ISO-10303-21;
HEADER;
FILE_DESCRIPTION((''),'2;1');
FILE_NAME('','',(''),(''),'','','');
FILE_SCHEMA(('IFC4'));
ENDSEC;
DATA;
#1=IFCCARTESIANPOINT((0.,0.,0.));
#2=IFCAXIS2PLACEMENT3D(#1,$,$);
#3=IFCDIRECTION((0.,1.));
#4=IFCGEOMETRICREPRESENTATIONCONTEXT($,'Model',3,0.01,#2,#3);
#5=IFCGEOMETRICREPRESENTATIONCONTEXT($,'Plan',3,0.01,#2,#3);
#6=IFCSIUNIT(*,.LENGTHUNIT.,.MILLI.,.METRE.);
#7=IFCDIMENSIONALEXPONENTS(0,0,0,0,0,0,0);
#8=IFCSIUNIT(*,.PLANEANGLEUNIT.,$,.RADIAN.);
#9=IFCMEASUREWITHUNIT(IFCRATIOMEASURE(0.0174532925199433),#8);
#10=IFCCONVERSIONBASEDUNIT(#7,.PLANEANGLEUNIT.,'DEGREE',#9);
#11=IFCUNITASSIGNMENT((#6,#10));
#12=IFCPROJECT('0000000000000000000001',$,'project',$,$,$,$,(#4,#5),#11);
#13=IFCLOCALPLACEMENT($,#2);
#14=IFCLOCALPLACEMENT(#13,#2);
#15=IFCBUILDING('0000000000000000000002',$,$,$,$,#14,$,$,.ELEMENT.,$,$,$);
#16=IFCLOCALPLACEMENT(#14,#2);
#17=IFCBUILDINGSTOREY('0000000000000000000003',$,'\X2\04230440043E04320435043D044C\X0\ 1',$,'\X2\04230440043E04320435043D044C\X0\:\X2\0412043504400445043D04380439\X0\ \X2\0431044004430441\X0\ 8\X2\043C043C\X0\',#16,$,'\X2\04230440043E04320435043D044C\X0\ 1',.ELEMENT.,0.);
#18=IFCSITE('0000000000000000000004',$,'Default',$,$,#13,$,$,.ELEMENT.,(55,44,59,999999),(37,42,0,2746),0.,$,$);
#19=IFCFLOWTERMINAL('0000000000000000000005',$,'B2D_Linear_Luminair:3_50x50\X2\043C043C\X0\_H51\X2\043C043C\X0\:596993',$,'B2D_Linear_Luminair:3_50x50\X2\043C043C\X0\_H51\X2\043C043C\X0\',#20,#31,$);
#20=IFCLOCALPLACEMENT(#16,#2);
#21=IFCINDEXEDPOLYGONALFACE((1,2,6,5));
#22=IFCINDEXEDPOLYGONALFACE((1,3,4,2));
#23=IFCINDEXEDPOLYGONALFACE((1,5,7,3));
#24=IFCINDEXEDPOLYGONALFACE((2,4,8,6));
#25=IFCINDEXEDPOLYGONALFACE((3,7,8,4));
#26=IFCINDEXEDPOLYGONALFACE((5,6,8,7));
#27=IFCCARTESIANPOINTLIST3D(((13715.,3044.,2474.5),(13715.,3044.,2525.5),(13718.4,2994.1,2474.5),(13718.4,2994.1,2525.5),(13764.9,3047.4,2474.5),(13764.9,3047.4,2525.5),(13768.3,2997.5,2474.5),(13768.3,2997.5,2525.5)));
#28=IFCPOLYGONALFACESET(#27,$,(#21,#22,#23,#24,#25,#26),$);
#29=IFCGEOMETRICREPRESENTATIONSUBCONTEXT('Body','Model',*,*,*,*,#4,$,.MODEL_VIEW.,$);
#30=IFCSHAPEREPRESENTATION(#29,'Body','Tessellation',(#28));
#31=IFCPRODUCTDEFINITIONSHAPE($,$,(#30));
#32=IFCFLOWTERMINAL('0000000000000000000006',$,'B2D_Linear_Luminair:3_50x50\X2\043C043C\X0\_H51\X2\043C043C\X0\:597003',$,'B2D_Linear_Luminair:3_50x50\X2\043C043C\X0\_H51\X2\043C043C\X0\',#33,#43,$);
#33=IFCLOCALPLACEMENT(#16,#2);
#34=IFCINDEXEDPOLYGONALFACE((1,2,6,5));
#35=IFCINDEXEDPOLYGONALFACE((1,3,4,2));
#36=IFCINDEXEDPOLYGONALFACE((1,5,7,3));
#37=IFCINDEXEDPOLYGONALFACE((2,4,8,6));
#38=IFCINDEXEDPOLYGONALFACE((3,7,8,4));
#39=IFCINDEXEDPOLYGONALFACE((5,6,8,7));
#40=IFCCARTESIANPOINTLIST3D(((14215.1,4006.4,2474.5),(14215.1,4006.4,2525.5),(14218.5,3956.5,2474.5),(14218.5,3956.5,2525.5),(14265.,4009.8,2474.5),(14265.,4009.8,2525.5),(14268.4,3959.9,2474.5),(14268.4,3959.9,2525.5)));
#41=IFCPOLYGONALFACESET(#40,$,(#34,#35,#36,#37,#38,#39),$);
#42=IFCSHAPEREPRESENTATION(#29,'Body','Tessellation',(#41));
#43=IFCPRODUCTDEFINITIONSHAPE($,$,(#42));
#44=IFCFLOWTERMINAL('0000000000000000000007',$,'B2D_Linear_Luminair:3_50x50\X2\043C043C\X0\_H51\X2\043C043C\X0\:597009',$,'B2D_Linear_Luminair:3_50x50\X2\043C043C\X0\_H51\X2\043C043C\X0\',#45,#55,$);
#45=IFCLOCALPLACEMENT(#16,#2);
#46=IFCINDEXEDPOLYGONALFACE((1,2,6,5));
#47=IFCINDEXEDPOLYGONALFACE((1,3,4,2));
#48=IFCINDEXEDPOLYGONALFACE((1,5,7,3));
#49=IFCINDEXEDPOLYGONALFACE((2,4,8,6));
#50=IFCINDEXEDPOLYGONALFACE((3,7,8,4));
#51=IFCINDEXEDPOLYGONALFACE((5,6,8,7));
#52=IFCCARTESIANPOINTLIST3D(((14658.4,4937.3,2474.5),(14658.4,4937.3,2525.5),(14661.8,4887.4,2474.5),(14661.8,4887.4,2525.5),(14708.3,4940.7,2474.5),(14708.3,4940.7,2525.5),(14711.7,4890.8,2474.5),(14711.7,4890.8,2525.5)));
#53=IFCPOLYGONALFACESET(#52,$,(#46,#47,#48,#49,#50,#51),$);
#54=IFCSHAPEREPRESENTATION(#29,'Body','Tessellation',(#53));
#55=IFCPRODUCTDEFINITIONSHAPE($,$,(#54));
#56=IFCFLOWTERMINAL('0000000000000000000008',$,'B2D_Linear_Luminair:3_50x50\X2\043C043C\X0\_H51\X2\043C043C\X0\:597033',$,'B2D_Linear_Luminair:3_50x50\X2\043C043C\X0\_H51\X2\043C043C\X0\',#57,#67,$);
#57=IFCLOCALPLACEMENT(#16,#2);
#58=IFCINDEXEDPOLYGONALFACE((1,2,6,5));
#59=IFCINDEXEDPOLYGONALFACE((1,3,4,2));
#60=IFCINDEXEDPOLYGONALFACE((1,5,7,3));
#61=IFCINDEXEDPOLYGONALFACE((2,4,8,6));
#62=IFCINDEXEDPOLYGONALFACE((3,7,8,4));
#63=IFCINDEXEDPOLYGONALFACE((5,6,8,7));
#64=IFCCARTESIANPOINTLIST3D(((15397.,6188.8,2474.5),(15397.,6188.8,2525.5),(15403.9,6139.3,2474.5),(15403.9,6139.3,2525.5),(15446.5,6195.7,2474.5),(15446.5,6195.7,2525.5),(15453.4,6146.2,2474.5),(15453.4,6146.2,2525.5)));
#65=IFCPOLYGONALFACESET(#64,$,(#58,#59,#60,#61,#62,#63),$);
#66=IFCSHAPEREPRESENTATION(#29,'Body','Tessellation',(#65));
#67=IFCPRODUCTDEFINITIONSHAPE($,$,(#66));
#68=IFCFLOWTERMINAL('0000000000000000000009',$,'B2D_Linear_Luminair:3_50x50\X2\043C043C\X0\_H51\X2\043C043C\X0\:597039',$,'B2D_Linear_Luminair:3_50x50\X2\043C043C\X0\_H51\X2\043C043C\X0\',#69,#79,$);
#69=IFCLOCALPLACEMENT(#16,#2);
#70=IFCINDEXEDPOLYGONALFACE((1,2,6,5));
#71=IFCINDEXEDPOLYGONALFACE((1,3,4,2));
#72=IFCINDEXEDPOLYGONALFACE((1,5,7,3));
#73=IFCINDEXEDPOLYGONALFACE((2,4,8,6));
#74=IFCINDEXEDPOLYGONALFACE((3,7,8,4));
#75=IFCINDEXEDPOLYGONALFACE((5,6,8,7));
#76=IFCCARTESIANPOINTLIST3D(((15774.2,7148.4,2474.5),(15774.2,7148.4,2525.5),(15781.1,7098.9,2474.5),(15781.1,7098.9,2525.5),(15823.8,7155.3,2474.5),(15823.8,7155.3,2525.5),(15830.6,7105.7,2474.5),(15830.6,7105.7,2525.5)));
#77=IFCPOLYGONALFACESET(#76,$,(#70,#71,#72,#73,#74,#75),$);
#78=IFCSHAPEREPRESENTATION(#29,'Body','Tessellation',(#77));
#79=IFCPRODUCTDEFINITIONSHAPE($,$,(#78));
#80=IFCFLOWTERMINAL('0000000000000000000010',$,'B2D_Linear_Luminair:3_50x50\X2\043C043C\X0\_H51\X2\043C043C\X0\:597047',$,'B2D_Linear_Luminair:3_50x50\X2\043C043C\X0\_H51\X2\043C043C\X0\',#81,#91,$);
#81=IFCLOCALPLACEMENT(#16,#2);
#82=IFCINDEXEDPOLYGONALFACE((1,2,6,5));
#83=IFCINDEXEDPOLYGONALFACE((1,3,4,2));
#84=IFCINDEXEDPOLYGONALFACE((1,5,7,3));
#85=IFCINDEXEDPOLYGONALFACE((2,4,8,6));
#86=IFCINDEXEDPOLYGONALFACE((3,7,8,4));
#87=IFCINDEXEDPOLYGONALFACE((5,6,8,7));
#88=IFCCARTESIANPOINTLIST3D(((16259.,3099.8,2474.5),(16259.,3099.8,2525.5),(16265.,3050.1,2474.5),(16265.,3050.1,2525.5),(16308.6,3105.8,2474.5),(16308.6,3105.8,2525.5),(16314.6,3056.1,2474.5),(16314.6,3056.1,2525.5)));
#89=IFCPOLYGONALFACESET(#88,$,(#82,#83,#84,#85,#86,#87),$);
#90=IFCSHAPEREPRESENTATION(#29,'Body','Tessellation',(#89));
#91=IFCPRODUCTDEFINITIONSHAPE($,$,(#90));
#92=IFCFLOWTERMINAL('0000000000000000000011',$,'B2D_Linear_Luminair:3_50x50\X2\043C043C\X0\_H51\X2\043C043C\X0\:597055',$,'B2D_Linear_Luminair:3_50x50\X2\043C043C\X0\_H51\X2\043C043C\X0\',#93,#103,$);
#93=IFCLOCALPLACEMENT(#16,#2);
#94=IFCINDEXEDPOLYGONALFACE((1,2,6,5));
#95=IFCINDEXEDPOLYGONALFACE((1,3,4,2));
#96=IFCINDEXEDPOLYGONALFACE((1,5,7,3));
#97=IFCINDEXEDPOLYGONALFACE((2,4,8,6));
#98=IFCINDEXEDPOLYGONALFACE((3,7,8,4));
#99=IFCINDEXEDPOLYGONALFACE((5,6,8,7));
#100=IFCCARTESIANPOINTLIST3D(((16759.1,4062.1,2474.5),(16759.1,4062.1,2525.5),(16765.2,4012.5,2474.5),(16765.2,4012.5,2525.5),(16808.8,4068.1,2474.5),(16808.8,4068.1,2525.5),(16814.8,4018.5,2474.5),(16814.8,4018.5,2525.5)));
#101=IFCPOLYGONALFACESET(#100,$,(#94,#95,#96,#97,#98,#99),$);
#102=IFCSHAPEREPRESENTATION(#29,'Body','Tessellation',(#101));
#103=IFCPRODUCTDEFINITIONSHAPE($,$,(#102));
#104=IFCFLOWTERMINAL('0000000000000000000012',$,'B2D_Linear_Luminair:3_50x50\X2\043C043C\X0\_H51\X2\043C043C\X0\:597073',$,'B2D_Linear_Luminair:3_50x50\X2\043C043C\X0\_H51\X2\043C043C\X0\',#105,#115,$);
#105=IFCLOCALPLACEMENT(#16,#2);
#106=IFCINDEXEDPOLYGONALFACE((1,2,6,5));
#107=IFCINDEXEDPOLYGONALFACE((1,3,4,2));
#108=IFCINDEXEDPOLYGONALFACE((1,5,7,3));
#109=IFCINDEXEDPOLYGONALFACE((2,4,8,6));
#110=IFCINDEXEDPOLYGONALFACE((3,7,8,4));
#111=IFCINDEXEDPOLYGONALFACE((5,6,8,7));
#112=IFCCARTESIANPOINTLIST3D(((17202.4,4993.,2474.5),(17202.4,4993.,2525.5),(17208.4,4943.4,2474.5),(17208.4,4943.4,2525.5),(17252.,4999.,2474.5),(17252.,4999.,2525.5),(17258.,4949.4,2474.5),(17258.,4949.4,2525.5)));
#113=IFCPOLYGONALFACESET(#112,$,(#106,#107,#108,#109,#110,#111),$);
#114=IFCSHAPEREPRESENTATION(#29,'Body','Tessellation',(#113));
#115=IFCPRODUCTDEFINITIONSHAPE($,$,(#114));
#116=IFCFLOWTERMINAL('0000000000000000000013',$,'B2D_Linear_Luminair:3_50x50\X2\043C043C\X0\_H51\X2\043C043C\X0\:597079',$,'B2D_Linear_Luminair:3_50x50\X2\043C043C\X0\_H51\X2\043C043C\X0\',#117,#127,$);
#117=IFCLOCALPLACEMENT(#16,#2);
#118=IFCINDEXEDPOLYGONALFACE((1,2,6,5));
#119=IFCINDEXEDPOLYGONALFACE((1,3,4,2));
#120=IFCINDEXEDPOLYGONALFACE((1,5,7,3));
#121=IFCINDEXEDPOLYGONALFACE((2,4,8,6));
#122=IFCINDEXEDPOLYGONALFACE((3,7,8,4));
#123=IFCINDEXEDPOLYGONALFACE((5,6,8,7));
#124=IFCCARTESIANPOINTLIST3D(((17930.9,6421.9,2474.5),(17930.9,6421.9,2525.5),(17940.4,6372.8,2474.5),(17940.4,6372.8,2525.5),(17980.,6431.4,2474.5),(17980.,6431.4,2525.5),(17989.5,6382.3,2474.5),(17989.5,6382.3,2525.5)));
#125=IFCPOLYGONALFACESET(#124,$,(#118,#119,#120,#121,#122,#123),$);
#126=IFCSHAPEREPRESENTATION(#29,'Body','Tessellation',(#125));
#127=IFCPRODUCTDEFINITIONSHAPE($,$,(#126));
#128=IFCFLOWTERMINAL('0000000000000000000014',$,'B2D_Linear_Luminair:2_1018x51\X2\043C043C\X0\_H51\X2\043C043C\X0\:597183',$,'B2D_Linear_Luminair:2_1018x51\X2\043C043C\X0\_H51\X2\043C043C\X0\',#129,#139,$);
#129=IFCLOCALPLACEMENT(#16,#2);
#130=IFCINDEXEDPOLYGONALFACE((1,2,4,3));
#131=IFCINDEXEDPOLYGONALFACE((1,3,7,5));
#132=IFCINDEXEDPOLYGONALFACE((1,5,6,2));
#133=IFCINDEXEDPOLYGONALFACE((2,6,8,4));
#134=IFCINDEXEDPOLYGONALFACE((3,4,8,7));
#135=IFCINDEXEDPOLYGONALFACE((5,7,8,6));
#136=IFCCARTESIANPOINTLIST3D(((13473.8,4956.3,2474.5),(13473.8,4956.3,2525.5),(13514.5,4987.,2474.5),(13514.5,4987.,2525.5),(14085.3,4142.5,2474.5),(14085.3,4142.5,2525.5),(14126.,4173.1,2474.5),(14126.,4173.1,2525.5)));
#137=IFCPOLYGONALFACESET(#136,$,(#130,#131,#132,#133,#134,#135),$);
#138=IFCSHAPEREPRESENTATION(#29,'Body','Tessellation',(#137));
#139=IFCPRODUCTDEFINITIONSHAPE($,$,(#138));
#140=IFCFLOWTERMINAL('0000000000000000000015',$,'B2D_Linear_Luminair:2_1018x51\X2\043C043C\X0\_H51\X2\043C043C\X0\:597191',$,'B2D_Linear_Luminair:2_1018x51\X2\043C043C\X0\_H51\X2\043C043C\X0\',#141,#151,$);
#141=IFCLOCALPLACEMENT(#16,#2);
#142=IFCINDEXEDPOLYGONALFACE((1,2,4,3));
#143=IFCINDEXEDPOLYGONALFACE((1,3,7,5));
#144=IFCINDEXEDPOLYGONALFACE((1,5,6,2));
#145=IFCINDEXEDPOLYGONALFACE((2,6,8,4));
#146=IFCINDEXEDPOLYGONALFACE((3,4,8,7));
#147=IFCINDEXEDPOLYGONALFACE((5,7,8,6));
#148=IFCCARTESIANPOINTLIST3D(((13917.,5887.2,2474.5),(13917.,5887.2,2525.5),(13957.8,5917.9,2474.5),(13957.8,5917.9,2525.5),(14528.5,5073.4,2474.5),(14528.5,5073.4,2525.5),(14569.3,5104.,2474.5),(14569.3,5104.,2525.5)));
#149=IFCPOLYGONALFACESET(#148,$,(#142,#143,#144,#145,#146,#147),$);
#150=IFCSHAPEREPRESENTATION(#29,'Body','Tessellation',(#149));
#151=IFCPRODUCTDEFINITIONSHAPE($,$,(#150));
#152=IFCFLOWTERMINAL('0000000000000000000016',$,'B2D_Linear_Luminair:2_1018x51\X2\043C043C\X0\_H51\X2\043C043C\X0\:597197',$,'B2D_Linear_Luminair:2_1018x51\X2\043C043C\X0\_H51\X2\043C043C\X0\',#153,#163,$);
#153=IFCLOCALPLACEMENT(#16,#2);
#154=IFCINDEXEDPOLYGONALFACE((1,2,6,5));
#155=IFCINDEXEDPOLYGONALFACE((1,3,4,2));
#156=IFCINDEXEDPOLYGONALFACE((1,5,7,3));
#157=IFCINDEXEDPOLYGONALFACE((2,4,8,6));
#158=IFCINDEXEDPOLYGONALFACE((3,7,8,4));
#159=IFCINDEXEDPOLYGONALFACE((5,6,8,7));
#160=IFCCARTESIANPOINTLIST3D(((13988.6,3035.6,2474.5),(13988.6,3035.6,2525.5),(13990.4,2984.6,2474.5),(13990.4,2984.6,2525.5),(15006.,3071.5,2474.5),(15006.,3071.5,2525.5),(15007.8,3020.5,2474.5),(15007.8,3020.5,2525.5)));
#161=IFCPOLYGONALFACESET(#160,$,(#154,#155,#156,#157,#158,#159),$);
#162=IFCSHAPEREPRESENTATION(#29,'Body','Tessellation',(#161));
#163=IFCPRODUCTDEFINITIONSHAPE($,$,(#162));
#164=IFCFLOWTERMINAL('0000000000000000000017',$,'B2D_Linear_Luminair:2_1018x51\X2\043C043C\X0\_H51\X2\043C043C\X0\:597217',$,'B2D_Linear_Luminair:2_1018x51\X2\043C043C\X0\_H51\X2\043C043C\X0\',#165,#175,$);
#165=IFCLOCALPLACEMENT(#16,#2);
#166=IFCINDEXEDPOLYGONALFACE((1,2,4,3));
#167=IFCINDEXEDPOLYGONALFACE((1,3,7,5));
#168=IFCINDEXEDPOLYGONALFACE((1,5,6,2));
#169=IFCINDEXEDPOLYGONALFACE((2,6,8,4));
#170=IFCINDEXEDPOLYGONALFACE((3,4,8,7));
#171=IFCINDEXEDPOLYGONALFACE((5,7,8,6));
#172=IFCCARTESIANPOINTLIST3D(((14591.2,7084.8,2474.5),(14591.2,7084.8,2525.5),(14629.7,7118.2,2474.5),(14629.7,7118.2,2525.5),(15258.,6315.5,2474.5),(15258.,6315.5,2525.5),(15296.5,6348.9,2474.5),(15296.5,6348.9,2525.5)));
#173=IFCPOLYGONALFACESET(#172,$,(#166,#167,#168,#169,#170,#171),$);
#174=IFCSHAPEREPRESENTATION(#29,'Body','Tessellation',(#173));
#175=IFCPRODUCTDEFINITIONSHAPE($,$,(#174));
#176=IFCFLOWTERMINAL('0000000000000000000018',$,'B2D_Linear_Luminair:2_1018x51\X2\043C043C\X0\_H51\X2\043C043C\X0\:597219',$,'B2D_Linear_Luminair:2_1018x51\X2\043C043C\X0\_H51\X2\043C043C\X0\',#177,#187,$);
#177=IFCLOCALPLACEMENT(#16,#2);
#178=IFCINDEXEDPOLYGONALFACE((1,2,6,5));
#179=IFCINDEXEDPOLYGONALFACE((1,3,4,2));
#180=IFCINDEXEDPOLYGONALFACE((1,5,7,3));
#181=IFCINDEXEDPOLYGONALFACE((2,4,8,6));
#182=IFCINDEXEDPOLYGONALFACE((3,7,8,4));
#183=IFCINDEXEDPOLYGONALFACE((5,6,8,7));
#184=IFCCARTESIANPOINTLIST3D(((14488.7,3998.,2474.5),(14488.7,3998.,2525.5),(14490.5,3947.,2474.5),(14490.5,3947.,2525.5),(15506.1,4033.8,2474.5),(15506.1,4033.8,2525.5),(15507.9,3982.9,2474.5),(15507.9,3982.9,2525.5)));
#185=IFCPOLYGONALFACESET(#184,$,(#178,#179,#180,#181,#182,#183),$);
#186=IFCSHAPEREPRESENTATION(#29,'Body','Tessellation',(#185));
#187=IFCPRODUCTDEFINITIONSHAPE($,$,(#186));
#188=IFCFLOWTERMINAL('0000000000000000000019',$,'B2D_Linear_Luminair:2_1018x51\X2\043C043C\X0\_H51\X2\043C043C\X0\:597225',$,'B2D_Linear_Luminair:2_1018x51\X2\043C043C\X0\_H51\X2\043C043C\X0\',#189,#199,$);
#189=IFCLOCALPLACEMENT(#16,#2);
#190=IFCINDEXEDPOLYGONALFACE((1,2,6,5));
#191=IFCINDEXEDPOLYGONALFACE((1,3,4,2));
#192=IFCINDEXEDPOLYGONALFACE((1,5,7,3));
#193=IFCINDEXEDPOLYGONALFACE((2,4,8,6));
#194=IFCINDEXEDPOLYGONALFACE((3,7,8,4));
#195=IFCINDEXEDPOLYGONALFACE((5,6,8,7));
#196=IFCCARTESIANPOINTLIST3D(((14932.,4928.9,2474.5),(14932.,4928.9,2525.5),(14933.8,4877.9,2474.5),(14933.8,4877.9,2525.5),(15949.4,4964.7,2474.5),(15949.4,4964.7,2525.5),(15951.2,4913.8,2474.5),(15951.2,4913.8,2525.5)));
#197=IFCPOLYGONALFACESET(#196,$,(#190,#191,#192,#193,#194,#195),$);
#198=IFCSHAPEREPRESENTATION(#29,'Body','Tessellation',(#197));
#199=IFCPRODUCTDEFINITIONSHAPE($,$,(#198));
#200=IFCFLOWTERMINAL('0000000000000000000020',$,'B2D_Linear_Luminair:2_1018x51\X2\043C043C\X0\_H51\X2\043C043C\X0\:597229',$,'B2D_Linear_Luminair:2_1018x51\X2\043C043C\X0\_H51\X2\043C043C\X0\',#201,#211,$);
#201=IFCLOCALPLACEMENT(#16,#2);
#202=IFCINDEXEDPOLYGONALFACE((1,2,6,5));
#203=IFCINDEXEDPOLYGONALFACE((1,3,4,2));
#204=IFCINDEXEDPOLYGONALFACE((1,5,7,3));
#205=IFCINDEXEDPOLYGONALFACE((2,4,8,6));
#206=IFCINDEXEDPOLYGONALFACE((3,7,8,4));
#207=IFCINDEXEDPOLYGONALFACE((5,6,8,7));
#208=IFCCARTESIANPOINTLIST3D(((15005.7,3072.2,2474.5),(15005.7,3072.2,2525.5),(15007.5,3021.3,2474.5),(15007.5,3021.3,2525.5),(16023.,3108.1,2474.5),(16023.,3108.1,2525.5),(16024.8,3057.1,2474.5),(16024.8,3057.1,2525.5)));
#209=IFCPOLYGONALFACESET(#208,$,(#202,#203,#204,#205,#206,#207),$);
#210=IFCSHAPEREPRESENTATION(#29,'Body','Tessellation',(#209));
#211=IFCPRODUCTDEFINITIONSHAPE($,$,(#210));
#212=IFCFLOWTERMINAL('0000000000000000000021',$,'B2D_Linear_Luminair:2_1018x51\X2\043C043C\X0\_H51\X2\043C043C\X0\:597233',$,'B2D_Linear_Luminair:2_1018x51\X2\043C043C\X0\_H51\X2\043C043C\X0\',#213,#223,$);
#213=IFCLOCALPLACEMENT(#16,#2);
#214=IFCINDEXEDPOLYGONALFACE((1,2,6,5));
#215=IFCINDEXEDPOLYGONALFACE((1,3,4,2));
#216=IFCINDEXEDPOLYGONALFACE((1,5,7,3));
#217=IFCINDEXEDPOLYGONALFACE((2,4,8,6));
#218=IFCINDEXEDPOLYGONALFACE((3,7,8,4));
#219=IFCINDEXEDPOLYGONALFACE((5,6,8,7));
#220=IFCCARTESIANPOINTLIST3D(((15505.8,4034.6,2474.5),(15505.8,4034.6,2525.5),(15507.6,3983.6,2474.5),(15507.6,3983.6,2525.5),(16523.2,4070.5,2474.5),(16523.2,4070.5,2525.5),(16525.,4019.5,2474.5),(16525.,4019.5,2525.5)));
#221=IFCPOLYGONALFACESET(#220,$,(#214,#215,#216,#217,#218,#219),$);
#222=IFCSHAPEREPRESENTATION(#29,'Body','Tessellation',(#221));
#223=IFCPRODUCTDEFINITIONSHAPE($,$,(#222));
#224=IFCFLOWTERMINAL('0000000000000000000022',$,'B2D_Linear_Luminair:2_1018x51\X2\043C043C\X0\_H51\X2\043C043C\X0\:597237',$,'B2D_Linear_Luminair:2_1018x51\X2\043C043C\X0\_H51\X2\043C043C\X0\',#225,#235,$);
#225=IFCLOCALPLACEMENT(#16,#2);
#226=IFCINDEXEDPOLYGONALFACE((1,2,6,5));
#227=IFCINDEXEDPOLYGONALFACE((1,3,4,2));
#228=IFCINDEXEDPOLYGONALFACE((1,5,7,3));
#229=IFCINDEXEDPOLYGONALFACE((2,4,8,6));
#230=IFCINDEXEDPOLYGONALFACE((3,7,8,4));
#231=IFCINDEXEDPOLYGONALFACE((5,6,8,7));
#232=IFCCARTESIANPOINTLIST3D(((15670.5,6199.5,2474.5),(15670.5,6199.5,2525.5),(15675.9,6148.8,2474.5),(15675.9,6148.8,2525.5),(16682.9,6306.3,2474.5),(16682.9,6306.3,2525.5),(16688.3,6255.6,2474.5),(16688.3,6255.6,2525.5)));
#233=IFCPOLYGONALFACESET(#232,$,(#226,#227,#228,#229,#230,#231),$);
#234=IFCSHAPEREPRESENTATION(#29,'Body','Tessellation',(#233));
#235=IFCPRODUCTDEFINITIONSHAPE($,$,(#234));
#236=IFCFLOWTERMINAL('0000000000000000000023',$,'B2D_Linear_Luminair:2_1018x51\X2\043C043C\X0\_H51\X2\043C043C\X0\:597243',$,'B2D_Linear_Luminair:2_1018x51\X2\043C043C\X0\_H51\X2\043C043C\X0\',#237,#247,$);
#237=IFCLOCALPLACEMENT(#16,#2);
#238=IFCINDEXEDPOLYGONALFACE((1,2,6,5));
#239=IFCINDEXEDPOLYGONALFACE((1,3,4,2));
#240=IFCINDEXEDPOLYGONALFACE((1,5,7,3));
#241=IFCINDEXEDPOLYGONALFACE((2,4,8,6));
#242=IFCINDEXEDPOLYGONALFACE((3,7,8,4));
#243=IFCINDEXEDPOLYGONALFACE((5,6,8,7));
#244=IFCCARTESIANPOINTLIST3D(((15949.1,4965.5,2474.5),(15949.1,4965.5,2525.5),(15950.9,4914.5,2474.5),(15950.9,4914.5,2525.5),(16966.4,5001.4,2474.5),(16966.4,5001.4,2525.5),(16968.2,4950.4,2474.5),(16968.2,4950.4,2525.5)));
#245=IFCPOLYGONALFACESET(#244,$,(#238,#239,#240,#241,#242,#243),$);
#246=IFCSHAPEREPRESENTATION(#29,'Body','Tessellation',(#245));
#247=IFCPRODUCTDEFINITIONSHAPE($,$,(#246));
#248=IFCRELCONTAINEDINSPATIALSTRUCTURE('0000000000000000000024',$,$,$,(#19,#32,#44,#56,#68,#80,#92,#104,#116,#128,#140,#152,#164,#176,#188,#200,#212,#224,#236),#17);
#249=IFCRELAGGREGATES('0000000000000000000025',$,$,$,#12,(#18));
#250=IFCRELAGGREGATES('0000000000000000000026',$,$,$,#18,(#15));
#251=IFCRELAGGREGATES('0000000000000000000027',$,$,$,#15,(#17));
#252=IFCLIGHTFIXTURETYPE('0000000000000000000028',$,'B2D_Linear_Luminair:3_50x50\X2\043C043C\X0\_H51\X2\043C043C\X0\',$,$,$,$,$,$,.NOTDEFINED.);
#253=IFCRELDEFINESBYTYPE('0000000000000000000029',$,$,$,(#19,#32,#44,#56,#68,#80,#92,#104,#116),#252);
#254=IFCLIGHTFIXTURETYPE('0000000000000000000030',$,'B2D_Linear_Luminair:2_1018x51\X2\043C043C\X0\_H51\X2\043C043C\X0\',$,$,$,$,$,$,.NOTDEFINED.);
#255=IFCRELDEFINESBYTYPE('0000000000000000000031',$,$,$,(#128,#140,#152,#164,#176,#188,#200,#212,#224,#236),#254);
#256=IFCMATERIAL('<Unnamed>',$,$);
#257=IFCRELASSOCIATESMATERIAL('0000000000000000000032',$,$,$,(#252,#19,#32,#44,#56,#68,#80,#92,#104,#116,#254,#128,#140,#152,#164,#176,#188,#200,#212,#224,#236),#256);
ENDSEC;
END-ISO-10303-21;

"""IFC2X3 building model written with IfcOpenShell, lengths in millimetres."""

from ifc_helpers import new_model, entity, si_unit, converted_unit, direction, frame, origin, origin_2d_with_axis, place, context, subcontext, project, spatial, rectangle, extrude, source, transform, mapped, material, type_object, type_shapes, element, save


model = new_model("IFC2X3")

# Units and contexts
model_context = context("Model", 3, precision=0.01, world=origin(), true_north=direction((0.0, 1.0)))
plan_context = context("Plan", 3, precision=0.01, world=origin(), true_north=direction((0.0, 1.0)))
body_context = subcontext(model_context, "Body", "Model", "MODEL_VIEW")
ifc_project = project(units=[si_unit("LENGTHUNIT", "METRE", prefix="MILLI"), converted_unit("PLANEANGLEUNIT", "DEGREE", entity("IfcRatioMeasure", 0.0174532925199433), si_unit("PLANEANGLEUNIT", "RADIAN"), dimensions=[0, 0, 0, 0, 0, 0, 0])], contexts=[model_context, plan_context])

# Site, building, storey
site_placement = place(None, origin())
site = spatial("IfcSite", under=ifc_project, at=site_placement, Name="Default", CompositionType="ELEMENT", RefLatitude=(55, 44, 59, 999999), RefLongitude=(37, 42, 0, 2746), RefElevation=0.0)
building_placement = place(site_placement, origin())
building = spatial("IfcBuilding", under=site, at=building_placement, CompositionType="ELEMENT")
storey_placement = place(building_placement, origin())
storey = spatial("IfcBuildingStorey", under=building, at=storey_placement, Name="Уровень 1", ObjectType="Уровень:Верхний брус 8мм", LongName="Уровень 1", CompositionType="ELEMENT", Elevation=0.0)

# Flow terminals
ifc_material = material(Name="<Unnamed>")
light_fixture_type_1 = type_object("IfcLightFixtureType", Name="B2D_Linear_Luminair:3_50x50мм_H51мм", PredefinedType="NOTDEFINED", material=ifc_material)
shared_shape_1 = source(origin(), body_context, "Body", "SweptSolid", [
    extrude(rectangle(XDim=50.0, YDim=50.0, at=origin_2d_with_axis()), frame((0.0, 0.0, 0.0), z_axis=(0.0, 0.0, 1.0), x_axis=(-1.0, 0.0, 0.0)), (0.0, 0.0, 1.0), 51.0),
])
type_shapes(light_fixture_type_1, [shared_shape_1])
for number, where, z_axis, x_axis, name in (
    (1, (13741.6, 3020.8, 2525.5), (0.0, 0.0, -1.0), (0.99766, 0.068364, 0.0), "B2D_Linear_Luminair:3_50x50мм_H51мм:596993"),
    (2, (14241.8, 3983.1, 2525.5), (0.0, 0.0, -1.0), (0.99766, 0.068364, 0.0), "B2D_Linear_Luminair:3_50x50мм_H51мм:597003"),
    (3, (14685.0, 4914.1, 2525.5), (0.0, 0.0, -1.0), (0.99766, 0.068364, 0.0), "B2D_Linear_Luminair:3_50x50мм_H51мм:597009"),
    (4, (15425.2, 6167.5, 2525.5), (0.0, 0.0, -1.0), (0.990461, 0.13779, 0.0), "B2D_Linear_Luminair:3_50x50мм_H51мм:597033"),
    (5, (15802.4, 7127.1, 2525.5), (0.0, 0.0, -1.0), (0.990461, 0.13779, 0.0), "B2D_Linear_Luminair:3_50x50мм_H51мм:597039"),
    (6, (16286.8, 3077.9, 2525.5), (0.0, 0.0, -1.0), (0.992715, 0.120483, 0.0), "B2D_Linear_Luminair:3_50x50мм_H51мм:597047"),
    (7, (16787.0, 4040.3, 2525.5), (0.0, 0.0, -1.0), (0.992715, 0.120483, 0.0), "B2D_Linear_Luminair:3_50x50мм_H51мм:597055"),
    (8, (17230.2, 4971.2, 2525.5), (0.0, 0.0, -1.0), (0.992715, 0.120483, 0.0), "B2D_Linear_Luminair:3_50x50мм_H51мм:597073"),
    (9, (17960.2, 6402.1, 2525.5), (0.0, 0.0, -1.0), (0.981893, 0.189438, 0.0), "B2D_Linear_Luminair:3_50x50мм_H51мм:597079"),
):
    element("IfcFlowTerminal", number, at=place(storey_placement, frame(where, z_axis=z_axis, x_axis=x_axis)), inside=storey, type_object=light_fixture_type_1, material=ifc_material, Name=name, ObjectType="B2D_Linear_Luminair:3_50x50мм_H51мм", context=body_context, shape_type="MappedRepresentation", body=[
        mapped(shared_shape_1, transform((0.0, 0.0, 0.0), scale=1.0)),
    ])
light_fixture_type_2 = type_object("IfcLightFixtureType", Name="B2D_Linear_Luminair:2_1018x51мм_H51мм", PredefinedType="NOTDEFINED", material=ifc_material)
shared_shape_2 = source(origin(), body_context, "Body", "SweptSolid", [
    extrude(rectangle(XDim=1018.0, YDim=51.0, at=origin_2d_with_axis()), frame((0.0, 0.0, 0.0), z_axis=(0.0, 0.0, 1.0), x_axis=(-1.0, 0.0, 0.0)), (0.0, 0.0, 1.0), 51.0),
])
type_shapes(light_fixture_type_2, [shared_shape_2])
for number, where, z_axis, x_axis, name in (
    (10, (13799.9, 4564.7, 2525.5), (0.0, 0.0, -1.0), (0.600699, -0.799475, 0.0), "B2D_Linear_Luminair:2_1018x51мм_H51мм:597183"),
    (11, (14243.1, 5495.6, 2525.5), (0.0, 0.0, -1.0), (0.600699, -0.799475, 0.0), "B2D_Linear_Luminair:2_1018x51мм_H51мм:597191"),
    (12, (14498.2, 3028.1, 2525.5), (0.0, 0.0, -1.0), (0.999379, 0.035248, 0.0), "B2D_Linear_Luminair:2_1018x51мм_H51мм:597197"),
    (13, (14943.8, 6716.9, 2525.5), (0.0, 0.0, -1.0), (0.655005, -0.755625, 0.0), "B2D_Linear_Luminair:2_1018x51мм_H51мм:597217"),
    (14, (14998.3, 3990.4, 2525.5), (0.0, 0.0, -1.0), (0.999379, 0.035248, 0.0), "B2D_Linear_Luminair:2_1018x51мм_H51мм:597219"),
    (15, (15441.6, 4921.3, 2525.5), (0.0, 0.0, -1.0), (0.999379, 0.035248, 0.0), "B2D_Linear_Luminair:2_1018x51мм_H51мм:597225"),
    (16, (15515.2, 3064.7, 2525.5), (0.0, 0.0, -1.0), (0.999379, 0.035248, 0.0), "B2D_Linear_Luminair:2_1018x51мм_H51мм:597229"),
    (17, (16015.4, 4027.1, 2525.5), (0.0, 0.0, -1.0), (0.999379, 0.035248, 0.0), "B2D_Linear_Luminair:2_1018x51мм_H51мм:597233"),
    (18, (16179.4, 6227.5, 2525.5), (0.0, 0.0, -1.0), (0.994485, 0.104876, 0.0), "B2D_Linear_Luminair:2_1018x51мм_H51мм:597237"),
    (19, (16458.7, 4958.0, 2525.5), (0.0, 0.0, -1.0), (0.999379, 0.035248, 0.0), "B2D_Linear_Luminair:2_1018x51мм_H51мм:597243"),
):
    element("IfcFlowTerminal", number, at=place(storey_placement, frame(where, z_axis=z_axis, x_axis=x_axis)), inside=storey, type_object=light_fixture_type_2, material=ifc_material, Name=name, ObjectType="B2D_Linear_Luminair:2_1018x51мм_H51мм", context=body_context, shape_type="MappedRepresentation", body=[
        mapped(shared_shape_2, transform((0.0, 0.0, 0.0), scale=1.0)),
    ])

save(model, "model.ifc")
